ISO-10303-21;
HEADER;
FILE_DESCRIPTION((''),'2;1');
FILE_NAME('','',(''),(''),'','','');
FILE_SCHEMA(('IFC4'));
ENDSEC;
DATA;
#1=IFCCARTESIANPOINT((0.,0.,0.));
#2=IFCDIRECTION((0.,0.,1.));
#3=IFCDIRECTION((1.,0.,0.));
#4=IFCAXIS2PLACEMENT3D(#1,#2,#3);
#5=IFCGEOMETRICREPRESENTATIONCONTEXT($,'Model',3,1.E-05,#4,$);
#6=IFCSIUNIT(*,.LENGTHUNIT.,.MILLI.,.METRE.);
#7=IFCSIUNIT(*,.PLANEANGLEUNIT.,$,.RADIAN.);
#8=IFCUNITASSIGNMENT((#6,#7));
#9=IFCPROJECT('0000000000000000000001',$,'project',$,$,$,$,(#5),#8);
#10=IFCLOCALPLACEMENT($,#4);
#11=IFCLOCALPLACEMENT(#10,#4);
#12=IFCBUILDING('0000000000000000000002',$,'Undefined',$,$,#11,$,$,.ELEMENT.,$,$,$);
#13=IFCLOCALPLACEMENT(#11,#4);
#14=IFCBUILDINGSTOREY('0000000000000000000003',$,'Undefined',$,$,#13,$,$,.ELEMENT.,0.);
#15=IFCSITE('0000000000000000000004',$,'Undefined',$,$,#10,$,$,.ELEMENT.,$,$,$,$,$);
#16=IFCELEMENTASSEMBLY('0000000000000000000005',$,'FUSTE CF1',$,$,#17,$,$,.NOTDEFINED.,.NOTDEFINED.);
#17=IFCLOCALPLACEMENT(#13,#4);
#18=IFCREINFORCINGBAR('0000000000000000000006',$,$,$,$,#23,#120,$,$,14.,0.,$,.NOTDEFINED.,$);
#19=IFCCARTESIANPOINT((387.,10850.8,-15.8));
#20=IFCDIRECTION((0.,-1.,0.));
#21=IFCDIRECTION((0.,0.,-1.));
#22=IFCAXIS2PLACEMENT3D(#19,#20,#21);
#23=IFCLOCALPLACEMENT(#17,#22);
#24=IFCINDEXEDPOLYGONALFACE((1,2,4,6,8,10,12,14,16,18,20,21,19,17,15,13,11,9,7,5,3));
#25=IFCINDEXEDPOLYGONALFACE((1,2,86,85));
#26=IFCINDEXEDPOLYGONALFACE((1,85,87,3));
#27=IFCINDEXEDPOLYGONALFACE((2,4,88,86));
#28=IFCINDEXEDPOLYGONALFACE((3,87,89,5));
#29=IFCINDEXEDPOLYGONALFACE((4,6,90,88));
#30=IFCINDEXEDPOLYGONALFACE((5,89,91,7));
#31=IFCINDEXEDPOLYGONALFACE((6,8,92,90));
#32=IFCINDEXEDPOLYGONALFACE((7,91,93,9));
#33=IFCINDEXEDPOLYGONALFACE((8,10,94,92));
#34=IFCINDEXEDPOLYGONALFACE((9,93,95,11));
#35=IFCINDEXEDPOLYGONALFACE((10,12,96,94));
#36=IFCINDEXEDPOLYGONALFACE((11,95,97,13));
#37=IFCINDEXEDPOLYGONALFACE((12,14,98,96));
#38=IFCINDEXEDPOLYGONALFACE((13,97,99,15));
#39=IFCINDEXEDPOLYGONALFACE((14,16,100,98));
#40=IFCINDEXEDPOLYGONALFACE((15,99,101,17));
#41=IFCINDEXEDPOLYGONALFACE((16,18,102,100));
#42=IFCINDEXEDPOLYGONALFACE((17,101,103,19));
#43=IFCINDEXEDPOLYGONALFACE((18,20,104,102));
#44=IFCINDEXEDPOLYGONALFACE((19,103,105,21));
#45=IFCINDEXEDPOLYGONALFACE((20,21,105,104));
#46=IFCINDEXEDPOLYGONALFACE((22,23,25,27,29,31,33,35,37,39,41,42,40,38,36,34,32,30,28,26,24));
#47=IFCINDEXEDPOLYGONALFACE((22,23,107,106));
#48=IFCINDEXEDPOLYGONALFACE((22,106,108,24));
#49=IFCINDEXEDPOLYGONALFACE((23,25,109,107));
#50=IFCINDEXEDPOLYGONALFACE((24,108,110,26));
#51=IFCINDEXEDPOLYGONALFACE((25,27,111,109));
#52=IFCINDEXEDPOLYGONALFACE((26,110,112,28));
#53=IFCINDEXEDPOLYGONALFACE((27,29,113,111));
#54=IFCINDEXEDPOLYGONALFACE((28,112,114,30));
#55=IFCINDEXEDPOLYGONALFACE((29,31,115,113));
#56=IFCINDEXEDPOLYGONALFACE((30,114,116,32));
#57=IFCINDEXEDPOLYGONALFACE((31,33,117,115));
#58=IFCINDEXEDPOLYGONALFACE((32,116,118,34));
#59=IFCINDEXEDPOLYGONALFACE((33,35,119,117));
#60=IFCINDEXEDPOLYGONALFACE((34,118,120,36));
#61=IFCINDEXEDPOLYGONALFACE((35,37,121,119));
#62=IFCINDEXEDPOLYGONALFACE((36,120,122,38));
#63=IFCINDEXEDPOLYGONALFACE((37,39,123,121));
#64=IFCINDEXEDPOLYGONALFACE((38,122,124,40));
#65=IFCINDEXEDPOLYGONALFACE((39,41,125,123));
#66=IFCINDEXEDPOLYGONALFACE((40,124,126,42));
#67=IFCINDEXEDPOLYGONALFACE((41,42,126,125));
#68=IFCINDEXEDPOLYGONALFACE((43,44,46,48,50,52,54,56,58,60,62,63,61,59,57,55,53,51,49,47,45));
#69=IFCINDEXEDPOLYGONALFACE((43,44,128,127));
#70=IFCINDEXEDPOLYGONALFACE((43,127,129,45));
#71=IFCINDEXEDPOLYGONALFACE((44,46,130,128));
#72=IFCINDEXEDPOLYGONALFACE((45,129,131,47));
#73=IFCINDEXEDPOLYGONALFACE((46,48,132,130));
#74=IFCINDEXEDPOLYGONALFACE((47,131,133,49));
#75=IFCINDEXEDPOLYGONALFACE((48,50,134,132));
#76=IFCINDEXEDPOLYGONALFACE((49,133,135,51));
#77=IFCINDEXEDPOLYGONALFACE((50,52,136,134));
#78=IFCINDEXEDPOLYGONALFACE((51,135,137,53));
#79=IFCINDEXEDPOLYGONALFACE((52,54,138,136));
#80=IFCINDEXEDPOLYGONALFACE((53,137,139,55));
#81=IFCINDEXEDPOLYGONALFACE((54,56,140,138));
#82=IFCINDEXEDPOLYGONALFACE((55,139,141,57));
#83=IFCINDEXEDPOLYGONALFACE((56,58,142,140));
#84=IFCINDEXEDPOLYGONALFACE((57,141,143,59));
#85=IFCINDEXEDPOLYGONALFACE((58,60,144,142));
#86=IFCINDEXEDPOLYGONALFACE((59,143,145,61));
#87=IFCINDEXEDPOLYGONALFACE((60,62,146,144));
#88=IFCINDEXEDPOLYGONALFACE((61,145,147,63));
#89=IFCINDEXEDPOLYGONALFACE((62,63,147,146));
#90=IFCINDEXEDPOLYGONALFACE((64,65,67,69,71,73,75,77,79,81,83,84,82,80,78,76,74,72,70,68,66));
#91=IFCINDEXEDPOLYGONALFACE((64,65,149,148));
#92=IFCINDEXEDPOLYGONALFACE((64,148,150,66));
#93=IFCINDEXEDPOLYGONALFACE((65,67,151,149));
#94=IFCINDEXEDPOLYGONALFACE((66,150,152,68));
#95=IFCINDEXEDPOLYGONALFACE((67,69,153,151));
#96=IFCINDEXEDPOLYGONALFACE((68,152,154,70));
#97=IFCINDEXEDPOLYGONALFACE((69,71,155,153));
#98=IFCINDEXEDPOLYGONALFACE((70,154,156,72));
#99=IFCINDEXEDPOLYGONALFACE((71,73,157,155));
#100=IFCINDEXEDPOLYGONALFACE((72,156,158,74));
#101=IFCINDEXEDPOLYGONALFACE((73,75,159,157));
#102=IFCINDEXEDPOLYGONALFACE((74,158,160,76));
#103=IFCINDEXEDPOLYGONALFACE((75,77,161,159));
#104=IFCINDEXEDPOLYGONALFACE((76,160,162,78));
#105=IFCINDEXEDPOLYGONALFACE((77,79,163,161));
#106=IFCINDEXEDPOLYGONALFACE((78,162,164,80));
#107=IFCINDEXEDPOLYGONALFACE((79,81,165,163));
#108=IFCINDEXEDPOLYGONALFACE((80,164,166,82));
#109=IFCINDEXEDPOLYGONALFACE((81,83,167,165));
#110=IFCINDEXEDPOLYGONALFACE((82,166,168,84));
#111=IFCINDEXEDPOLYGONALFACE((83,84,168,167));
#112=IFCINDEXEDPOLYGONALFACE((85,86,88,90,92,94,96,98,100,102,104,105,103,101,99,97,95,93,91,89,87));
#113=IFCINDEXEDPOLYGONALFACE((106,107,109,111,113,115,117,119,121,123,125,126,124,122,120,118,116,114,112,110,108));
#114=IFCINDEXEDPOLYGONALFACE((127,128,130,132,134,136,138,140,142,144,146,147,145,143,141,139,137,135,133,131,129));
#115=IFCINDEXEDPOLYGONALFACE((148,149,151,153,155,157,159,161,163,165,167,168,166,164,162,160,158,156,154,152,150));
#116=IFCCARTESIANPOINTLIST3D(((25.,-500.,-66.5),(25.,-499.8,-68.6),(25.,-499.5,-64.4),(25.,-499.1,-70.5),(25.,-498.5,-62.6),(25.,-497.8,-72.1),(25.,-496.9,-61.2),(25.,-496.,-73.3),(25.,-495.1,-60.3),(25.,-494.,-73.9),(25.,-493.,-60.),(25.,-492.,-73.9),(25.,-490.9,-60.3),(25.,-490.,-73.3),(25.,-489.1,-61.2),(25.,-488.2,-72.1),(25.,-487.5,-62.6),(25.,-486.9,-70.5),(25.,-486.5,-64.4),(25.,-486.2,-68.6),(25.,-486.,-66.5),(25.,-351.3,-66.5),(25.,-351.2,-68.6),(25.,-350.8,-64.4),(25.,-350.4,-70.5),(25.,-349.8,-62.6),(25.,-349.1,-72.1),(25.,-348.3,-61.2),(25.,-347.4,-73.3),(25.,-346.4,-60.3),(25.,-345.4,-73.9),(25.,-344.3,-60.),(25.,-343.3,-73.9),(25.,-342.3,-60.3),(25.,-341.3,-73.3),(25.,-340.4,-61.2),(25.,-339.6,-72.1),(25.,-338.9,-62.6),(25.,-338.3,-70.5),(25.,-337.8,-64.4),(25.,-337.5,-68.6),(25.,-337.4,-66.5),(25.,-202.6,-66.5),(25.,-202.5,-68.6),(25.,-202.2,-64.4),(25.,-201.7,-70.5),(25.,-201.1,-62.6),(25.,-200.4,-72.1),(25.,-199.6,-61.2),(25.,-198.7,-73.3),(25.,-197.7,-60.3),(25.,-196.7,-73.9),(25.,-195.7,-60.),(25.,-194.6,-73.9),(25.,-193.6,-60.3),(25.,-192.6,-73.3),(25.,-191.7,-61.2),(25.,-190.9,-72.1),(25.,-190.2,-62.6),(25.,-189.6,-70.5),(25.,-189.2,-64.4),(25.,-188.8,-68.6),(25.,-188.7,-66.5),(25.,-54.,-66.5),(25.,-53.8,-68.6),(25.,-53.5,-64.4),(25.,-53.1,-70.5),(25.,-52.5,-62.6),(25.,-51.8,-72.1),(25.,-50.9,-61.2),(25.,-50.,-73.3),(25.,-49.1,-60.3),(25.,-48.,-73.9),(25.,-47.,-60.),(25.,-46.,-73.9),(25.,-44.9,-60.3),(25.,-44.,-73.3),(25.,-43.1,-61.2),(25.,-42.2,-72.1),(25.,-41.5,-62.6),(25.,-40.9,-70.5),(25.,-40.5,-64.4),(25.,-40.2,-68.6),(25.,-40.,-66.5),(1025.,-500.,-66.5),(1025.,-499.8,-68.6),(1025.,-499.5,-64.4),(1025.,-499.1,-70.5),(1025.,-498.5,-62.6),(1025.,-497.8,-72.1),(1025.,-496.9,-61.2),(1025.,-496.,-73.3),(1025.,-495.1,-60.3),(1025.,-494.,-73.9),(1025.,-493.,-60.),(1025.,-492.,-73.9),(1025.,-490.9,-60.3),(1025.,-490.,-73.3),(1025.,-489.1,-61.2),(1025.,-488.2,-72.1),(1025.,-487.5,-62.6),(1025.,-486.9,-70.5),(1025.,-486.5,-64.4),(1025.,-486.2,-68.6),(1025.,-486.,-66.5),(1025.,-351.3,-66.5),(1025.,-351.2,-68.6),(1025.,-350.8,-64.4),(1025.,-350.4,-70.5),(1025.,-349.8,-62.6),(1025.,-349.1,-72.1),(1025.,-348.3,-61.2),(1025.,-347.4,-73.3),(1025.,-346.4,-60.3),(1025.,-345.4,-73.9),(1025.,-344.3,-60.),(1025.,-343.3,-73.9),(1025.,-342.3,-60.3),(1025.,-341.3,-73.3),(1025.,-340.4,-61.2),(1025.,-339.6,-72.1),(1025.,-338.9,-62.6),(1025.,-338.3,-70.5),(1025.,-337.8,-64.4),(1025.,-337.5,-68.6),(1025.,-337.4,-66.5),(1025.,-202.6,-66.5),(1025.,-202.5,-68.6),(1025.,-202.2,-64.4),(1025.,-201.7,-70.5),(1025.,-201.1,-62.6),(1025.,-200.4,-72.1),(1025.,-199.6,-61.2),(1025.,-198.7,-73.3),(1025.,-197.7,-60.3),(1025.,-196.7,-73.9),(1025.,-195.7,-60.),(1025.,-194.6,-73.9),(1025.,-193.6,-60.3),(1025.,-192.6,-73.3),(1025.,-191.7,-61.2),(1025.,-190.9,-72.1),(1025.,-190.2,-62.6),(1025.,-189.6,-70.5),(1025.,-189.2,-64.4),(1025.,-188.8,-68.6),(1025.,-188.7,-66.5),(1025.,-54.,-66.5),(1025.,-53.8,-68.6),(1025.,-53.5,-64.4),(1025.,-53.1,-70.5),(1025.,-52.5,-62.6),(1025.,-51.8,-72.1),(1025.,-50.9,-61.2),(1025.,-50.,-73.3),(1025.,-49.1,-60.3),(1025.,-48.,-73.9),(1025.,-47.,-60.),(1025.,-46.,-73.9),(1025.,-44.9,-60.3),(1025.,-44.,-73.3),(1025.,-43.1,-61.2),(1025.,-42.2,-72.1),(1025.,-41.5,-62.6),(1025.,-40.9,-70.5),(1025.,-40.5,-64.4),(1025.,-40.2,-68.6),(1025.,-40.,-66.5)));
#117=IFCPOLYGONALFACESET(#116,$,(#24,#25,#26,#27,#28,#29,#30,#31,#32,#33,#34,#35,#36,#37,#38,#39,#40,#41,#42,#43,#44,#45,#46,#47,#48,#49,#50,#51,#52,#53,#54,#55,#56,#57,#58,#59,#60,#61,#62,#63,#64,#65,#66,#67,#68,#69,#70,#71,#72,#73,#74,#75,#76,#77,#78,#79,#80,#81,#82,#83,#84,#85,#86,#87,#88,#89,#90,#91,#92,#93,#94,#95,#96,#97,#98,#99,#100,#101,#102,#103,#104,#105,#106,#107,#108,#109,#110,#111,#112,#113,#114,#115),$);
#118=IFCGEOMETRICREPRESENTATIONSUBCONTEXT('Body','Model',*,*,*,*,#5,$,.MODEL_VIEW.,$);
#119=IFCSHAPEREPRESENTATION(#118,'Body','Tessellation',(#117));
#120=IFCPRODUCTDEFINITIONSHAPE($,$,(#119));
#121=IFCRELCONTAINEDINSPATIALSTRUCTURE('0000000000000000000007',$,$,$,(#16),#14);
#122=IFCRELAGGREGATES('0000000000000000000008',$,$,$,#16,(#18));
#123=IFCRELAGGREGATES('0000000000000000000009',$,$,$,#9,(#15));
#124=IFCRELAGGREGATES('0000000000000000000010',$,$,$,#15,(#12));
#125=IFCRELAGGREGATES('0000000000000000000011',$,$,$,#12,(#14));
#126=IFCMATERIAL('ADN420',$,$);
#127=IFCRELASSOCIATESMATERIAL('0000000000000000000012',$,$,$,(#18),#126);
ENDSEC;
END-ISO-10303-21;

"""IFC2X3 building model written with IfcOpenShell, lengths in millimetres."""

from ifc_helpers import new_model, entity, si_unit, frame, origin_with_axes, place, context, subcontext, project, spatial, source, transform, mapped, material, element, aggregate, save


model = new_model("IFC2X3")

# Units and contexts
model_context = context("Model", 3, precision=1e-05, world=origin_with_axes())
body_context = subcontext(model_context, "Body", "Model", "MODEL_VIEW")
ifc_project = project(units=[si_unit("LENGTHUNIT", "METRE", prefix="MILLI"), si_unit("PLANEANGLEUNIT", "RADIAN")], contexts=[model_context])

# Site, building, storey
site_placement = place(None, origin_with_axes())
site = spatial("IfcSite", under=ifc_project, at=site_placement, Name="Undefined", CompositionType="ELEMENT")
building_placement = place(site_placement, origin_with_axes())
building = spatial("IfcBuilding", under=site, at=building_placement, Name="Undefined", CompositionType="ELEMENT")
storey_placement = place(building_placement, origin_with_axes())
storey = spatial("IfcBuildingStorey", under=building, at=storey_placement, Name="Undefined", CompositionType="ELEMENT", Elevation=0.0)

# Shared definitions
ifc_material_1 = material(Name="ADN420")

# Element assembly, reinforcing bar
assembly_1_placement = place(storey_placement, origin_with_axes())
assembly_1 = element("IfcElementAssembly", 1, at=assembly_1_placement, inside=storey, Name="FUSTE CF1", AssemblyPlace="NOTDEFINED", PredefinedType="NOTDEFINED")
shared_shape_1 = source(origin_with_axes(), body_context, "Body", "AdvancedSweptSolid", [
    entity("IfcSweptDiskSolid", entity("IfcTrimmedCurve", entity("IfcLine", entity("IfcCartesianPoint", [0.0, 0.0, 0.0]), entity("IfcVector", entity("IfcDirection", [1.0, 0.0, 0.0]), 1.0)), [entity("IfcParameterValue", 0.0)], [entity("IfcParameterValue", 1000.0)], True, "PARAMETER"), 7.0, None, 0.0, 1000.0),
])
shared_shape_2 = source(origin_with_axes(), body_context, "Body", "AdvancedSweptSolid", [
    entity("IfcSweptDiskSolid", entity("IfcTrimmedCurve", entity("IfcLine", entity("IfcCartesianPoint", [0.0, 0.0, 0.0]), entity("IfcVector", entity("IfcDirection", [1.0, 0.0, 0.0]), 1.0)), [entity("IfcParameterValue", 0.0)], [entity("IfcParameterValue", 1000.0)], True, "PARAMETER"), 7.0, None, 0.0, 1000.0),
])
shared_shape_3 = source(origin_with_axes(), body_context, "Body", "AdvancedSweptSolid", [
    entity("IfcSweptDiskSolid", entity("IfcTrimmedCurve", entity("IfcLine", entity("IfcCartesianPoint", [0.0, 0.0, 0.0]), entity("IfcVector", entity("IfcDirection", [1.0, 0.0, 0.0]), 1.0)), [entity("IfcParameterValue", 0.0)], [entity("IfcParameterValue", 1000.0)], True, "PARAMETER"), 7.0, None, 0.0, 1000.0),
])
shared_shape_4 = source(origin_with_axes(), body_context, "Body", "AdvancedSweptSolid", [
    entity("IfcSweptDiskSolid", entity("IfcTrimmedCurve", entity("IfcLine", entity("IfcCartesianPoint", [0.0, 0.0, 0.0]), entity("IfcVector", entity("IfcDirection", [1.0, 0.0, 0.0]), 1.0)), [entity("IfcParameterValue", 0.0)], [entity("IfcParameterValue", 1000.0)], True, "PARAMETER"), 7.0, None, 0.0, 1000.0),
])
reinforcing_bar_1_placement = place(assembly_1_placement, frame((387.0, 10850.8, -15.8), z_axis=(0.0, -1.0, 0.0), x_axis=(0.0, 0.0, -1.0)))
reinforcing_bar_1 = element("IfcReinforcingBar", 2, at=reinforcing_bar_1_placement, material=ifc_material_1, BarRole="NOTDEFINED", CrossSectionArea=0.0, NominalDiameter=14.0, context=body_context, shape_type="MappedRepresentation", body=[
    mapped(shared_shape_1, transform((25.0, -493.0, -67.0))),
    mapped(shared_shape_2, transform((25.0, -344.3, -67.0))),
    mapped(shared_shape_3, transform((25.0, -195.7, -67.0))),
    mapped(shared_shape_4, transform((25.0, -47.0, -67.0))),
])
aggregate(assembly_1, [reinforcing_bar_1])

save(model, "model.ifc")
